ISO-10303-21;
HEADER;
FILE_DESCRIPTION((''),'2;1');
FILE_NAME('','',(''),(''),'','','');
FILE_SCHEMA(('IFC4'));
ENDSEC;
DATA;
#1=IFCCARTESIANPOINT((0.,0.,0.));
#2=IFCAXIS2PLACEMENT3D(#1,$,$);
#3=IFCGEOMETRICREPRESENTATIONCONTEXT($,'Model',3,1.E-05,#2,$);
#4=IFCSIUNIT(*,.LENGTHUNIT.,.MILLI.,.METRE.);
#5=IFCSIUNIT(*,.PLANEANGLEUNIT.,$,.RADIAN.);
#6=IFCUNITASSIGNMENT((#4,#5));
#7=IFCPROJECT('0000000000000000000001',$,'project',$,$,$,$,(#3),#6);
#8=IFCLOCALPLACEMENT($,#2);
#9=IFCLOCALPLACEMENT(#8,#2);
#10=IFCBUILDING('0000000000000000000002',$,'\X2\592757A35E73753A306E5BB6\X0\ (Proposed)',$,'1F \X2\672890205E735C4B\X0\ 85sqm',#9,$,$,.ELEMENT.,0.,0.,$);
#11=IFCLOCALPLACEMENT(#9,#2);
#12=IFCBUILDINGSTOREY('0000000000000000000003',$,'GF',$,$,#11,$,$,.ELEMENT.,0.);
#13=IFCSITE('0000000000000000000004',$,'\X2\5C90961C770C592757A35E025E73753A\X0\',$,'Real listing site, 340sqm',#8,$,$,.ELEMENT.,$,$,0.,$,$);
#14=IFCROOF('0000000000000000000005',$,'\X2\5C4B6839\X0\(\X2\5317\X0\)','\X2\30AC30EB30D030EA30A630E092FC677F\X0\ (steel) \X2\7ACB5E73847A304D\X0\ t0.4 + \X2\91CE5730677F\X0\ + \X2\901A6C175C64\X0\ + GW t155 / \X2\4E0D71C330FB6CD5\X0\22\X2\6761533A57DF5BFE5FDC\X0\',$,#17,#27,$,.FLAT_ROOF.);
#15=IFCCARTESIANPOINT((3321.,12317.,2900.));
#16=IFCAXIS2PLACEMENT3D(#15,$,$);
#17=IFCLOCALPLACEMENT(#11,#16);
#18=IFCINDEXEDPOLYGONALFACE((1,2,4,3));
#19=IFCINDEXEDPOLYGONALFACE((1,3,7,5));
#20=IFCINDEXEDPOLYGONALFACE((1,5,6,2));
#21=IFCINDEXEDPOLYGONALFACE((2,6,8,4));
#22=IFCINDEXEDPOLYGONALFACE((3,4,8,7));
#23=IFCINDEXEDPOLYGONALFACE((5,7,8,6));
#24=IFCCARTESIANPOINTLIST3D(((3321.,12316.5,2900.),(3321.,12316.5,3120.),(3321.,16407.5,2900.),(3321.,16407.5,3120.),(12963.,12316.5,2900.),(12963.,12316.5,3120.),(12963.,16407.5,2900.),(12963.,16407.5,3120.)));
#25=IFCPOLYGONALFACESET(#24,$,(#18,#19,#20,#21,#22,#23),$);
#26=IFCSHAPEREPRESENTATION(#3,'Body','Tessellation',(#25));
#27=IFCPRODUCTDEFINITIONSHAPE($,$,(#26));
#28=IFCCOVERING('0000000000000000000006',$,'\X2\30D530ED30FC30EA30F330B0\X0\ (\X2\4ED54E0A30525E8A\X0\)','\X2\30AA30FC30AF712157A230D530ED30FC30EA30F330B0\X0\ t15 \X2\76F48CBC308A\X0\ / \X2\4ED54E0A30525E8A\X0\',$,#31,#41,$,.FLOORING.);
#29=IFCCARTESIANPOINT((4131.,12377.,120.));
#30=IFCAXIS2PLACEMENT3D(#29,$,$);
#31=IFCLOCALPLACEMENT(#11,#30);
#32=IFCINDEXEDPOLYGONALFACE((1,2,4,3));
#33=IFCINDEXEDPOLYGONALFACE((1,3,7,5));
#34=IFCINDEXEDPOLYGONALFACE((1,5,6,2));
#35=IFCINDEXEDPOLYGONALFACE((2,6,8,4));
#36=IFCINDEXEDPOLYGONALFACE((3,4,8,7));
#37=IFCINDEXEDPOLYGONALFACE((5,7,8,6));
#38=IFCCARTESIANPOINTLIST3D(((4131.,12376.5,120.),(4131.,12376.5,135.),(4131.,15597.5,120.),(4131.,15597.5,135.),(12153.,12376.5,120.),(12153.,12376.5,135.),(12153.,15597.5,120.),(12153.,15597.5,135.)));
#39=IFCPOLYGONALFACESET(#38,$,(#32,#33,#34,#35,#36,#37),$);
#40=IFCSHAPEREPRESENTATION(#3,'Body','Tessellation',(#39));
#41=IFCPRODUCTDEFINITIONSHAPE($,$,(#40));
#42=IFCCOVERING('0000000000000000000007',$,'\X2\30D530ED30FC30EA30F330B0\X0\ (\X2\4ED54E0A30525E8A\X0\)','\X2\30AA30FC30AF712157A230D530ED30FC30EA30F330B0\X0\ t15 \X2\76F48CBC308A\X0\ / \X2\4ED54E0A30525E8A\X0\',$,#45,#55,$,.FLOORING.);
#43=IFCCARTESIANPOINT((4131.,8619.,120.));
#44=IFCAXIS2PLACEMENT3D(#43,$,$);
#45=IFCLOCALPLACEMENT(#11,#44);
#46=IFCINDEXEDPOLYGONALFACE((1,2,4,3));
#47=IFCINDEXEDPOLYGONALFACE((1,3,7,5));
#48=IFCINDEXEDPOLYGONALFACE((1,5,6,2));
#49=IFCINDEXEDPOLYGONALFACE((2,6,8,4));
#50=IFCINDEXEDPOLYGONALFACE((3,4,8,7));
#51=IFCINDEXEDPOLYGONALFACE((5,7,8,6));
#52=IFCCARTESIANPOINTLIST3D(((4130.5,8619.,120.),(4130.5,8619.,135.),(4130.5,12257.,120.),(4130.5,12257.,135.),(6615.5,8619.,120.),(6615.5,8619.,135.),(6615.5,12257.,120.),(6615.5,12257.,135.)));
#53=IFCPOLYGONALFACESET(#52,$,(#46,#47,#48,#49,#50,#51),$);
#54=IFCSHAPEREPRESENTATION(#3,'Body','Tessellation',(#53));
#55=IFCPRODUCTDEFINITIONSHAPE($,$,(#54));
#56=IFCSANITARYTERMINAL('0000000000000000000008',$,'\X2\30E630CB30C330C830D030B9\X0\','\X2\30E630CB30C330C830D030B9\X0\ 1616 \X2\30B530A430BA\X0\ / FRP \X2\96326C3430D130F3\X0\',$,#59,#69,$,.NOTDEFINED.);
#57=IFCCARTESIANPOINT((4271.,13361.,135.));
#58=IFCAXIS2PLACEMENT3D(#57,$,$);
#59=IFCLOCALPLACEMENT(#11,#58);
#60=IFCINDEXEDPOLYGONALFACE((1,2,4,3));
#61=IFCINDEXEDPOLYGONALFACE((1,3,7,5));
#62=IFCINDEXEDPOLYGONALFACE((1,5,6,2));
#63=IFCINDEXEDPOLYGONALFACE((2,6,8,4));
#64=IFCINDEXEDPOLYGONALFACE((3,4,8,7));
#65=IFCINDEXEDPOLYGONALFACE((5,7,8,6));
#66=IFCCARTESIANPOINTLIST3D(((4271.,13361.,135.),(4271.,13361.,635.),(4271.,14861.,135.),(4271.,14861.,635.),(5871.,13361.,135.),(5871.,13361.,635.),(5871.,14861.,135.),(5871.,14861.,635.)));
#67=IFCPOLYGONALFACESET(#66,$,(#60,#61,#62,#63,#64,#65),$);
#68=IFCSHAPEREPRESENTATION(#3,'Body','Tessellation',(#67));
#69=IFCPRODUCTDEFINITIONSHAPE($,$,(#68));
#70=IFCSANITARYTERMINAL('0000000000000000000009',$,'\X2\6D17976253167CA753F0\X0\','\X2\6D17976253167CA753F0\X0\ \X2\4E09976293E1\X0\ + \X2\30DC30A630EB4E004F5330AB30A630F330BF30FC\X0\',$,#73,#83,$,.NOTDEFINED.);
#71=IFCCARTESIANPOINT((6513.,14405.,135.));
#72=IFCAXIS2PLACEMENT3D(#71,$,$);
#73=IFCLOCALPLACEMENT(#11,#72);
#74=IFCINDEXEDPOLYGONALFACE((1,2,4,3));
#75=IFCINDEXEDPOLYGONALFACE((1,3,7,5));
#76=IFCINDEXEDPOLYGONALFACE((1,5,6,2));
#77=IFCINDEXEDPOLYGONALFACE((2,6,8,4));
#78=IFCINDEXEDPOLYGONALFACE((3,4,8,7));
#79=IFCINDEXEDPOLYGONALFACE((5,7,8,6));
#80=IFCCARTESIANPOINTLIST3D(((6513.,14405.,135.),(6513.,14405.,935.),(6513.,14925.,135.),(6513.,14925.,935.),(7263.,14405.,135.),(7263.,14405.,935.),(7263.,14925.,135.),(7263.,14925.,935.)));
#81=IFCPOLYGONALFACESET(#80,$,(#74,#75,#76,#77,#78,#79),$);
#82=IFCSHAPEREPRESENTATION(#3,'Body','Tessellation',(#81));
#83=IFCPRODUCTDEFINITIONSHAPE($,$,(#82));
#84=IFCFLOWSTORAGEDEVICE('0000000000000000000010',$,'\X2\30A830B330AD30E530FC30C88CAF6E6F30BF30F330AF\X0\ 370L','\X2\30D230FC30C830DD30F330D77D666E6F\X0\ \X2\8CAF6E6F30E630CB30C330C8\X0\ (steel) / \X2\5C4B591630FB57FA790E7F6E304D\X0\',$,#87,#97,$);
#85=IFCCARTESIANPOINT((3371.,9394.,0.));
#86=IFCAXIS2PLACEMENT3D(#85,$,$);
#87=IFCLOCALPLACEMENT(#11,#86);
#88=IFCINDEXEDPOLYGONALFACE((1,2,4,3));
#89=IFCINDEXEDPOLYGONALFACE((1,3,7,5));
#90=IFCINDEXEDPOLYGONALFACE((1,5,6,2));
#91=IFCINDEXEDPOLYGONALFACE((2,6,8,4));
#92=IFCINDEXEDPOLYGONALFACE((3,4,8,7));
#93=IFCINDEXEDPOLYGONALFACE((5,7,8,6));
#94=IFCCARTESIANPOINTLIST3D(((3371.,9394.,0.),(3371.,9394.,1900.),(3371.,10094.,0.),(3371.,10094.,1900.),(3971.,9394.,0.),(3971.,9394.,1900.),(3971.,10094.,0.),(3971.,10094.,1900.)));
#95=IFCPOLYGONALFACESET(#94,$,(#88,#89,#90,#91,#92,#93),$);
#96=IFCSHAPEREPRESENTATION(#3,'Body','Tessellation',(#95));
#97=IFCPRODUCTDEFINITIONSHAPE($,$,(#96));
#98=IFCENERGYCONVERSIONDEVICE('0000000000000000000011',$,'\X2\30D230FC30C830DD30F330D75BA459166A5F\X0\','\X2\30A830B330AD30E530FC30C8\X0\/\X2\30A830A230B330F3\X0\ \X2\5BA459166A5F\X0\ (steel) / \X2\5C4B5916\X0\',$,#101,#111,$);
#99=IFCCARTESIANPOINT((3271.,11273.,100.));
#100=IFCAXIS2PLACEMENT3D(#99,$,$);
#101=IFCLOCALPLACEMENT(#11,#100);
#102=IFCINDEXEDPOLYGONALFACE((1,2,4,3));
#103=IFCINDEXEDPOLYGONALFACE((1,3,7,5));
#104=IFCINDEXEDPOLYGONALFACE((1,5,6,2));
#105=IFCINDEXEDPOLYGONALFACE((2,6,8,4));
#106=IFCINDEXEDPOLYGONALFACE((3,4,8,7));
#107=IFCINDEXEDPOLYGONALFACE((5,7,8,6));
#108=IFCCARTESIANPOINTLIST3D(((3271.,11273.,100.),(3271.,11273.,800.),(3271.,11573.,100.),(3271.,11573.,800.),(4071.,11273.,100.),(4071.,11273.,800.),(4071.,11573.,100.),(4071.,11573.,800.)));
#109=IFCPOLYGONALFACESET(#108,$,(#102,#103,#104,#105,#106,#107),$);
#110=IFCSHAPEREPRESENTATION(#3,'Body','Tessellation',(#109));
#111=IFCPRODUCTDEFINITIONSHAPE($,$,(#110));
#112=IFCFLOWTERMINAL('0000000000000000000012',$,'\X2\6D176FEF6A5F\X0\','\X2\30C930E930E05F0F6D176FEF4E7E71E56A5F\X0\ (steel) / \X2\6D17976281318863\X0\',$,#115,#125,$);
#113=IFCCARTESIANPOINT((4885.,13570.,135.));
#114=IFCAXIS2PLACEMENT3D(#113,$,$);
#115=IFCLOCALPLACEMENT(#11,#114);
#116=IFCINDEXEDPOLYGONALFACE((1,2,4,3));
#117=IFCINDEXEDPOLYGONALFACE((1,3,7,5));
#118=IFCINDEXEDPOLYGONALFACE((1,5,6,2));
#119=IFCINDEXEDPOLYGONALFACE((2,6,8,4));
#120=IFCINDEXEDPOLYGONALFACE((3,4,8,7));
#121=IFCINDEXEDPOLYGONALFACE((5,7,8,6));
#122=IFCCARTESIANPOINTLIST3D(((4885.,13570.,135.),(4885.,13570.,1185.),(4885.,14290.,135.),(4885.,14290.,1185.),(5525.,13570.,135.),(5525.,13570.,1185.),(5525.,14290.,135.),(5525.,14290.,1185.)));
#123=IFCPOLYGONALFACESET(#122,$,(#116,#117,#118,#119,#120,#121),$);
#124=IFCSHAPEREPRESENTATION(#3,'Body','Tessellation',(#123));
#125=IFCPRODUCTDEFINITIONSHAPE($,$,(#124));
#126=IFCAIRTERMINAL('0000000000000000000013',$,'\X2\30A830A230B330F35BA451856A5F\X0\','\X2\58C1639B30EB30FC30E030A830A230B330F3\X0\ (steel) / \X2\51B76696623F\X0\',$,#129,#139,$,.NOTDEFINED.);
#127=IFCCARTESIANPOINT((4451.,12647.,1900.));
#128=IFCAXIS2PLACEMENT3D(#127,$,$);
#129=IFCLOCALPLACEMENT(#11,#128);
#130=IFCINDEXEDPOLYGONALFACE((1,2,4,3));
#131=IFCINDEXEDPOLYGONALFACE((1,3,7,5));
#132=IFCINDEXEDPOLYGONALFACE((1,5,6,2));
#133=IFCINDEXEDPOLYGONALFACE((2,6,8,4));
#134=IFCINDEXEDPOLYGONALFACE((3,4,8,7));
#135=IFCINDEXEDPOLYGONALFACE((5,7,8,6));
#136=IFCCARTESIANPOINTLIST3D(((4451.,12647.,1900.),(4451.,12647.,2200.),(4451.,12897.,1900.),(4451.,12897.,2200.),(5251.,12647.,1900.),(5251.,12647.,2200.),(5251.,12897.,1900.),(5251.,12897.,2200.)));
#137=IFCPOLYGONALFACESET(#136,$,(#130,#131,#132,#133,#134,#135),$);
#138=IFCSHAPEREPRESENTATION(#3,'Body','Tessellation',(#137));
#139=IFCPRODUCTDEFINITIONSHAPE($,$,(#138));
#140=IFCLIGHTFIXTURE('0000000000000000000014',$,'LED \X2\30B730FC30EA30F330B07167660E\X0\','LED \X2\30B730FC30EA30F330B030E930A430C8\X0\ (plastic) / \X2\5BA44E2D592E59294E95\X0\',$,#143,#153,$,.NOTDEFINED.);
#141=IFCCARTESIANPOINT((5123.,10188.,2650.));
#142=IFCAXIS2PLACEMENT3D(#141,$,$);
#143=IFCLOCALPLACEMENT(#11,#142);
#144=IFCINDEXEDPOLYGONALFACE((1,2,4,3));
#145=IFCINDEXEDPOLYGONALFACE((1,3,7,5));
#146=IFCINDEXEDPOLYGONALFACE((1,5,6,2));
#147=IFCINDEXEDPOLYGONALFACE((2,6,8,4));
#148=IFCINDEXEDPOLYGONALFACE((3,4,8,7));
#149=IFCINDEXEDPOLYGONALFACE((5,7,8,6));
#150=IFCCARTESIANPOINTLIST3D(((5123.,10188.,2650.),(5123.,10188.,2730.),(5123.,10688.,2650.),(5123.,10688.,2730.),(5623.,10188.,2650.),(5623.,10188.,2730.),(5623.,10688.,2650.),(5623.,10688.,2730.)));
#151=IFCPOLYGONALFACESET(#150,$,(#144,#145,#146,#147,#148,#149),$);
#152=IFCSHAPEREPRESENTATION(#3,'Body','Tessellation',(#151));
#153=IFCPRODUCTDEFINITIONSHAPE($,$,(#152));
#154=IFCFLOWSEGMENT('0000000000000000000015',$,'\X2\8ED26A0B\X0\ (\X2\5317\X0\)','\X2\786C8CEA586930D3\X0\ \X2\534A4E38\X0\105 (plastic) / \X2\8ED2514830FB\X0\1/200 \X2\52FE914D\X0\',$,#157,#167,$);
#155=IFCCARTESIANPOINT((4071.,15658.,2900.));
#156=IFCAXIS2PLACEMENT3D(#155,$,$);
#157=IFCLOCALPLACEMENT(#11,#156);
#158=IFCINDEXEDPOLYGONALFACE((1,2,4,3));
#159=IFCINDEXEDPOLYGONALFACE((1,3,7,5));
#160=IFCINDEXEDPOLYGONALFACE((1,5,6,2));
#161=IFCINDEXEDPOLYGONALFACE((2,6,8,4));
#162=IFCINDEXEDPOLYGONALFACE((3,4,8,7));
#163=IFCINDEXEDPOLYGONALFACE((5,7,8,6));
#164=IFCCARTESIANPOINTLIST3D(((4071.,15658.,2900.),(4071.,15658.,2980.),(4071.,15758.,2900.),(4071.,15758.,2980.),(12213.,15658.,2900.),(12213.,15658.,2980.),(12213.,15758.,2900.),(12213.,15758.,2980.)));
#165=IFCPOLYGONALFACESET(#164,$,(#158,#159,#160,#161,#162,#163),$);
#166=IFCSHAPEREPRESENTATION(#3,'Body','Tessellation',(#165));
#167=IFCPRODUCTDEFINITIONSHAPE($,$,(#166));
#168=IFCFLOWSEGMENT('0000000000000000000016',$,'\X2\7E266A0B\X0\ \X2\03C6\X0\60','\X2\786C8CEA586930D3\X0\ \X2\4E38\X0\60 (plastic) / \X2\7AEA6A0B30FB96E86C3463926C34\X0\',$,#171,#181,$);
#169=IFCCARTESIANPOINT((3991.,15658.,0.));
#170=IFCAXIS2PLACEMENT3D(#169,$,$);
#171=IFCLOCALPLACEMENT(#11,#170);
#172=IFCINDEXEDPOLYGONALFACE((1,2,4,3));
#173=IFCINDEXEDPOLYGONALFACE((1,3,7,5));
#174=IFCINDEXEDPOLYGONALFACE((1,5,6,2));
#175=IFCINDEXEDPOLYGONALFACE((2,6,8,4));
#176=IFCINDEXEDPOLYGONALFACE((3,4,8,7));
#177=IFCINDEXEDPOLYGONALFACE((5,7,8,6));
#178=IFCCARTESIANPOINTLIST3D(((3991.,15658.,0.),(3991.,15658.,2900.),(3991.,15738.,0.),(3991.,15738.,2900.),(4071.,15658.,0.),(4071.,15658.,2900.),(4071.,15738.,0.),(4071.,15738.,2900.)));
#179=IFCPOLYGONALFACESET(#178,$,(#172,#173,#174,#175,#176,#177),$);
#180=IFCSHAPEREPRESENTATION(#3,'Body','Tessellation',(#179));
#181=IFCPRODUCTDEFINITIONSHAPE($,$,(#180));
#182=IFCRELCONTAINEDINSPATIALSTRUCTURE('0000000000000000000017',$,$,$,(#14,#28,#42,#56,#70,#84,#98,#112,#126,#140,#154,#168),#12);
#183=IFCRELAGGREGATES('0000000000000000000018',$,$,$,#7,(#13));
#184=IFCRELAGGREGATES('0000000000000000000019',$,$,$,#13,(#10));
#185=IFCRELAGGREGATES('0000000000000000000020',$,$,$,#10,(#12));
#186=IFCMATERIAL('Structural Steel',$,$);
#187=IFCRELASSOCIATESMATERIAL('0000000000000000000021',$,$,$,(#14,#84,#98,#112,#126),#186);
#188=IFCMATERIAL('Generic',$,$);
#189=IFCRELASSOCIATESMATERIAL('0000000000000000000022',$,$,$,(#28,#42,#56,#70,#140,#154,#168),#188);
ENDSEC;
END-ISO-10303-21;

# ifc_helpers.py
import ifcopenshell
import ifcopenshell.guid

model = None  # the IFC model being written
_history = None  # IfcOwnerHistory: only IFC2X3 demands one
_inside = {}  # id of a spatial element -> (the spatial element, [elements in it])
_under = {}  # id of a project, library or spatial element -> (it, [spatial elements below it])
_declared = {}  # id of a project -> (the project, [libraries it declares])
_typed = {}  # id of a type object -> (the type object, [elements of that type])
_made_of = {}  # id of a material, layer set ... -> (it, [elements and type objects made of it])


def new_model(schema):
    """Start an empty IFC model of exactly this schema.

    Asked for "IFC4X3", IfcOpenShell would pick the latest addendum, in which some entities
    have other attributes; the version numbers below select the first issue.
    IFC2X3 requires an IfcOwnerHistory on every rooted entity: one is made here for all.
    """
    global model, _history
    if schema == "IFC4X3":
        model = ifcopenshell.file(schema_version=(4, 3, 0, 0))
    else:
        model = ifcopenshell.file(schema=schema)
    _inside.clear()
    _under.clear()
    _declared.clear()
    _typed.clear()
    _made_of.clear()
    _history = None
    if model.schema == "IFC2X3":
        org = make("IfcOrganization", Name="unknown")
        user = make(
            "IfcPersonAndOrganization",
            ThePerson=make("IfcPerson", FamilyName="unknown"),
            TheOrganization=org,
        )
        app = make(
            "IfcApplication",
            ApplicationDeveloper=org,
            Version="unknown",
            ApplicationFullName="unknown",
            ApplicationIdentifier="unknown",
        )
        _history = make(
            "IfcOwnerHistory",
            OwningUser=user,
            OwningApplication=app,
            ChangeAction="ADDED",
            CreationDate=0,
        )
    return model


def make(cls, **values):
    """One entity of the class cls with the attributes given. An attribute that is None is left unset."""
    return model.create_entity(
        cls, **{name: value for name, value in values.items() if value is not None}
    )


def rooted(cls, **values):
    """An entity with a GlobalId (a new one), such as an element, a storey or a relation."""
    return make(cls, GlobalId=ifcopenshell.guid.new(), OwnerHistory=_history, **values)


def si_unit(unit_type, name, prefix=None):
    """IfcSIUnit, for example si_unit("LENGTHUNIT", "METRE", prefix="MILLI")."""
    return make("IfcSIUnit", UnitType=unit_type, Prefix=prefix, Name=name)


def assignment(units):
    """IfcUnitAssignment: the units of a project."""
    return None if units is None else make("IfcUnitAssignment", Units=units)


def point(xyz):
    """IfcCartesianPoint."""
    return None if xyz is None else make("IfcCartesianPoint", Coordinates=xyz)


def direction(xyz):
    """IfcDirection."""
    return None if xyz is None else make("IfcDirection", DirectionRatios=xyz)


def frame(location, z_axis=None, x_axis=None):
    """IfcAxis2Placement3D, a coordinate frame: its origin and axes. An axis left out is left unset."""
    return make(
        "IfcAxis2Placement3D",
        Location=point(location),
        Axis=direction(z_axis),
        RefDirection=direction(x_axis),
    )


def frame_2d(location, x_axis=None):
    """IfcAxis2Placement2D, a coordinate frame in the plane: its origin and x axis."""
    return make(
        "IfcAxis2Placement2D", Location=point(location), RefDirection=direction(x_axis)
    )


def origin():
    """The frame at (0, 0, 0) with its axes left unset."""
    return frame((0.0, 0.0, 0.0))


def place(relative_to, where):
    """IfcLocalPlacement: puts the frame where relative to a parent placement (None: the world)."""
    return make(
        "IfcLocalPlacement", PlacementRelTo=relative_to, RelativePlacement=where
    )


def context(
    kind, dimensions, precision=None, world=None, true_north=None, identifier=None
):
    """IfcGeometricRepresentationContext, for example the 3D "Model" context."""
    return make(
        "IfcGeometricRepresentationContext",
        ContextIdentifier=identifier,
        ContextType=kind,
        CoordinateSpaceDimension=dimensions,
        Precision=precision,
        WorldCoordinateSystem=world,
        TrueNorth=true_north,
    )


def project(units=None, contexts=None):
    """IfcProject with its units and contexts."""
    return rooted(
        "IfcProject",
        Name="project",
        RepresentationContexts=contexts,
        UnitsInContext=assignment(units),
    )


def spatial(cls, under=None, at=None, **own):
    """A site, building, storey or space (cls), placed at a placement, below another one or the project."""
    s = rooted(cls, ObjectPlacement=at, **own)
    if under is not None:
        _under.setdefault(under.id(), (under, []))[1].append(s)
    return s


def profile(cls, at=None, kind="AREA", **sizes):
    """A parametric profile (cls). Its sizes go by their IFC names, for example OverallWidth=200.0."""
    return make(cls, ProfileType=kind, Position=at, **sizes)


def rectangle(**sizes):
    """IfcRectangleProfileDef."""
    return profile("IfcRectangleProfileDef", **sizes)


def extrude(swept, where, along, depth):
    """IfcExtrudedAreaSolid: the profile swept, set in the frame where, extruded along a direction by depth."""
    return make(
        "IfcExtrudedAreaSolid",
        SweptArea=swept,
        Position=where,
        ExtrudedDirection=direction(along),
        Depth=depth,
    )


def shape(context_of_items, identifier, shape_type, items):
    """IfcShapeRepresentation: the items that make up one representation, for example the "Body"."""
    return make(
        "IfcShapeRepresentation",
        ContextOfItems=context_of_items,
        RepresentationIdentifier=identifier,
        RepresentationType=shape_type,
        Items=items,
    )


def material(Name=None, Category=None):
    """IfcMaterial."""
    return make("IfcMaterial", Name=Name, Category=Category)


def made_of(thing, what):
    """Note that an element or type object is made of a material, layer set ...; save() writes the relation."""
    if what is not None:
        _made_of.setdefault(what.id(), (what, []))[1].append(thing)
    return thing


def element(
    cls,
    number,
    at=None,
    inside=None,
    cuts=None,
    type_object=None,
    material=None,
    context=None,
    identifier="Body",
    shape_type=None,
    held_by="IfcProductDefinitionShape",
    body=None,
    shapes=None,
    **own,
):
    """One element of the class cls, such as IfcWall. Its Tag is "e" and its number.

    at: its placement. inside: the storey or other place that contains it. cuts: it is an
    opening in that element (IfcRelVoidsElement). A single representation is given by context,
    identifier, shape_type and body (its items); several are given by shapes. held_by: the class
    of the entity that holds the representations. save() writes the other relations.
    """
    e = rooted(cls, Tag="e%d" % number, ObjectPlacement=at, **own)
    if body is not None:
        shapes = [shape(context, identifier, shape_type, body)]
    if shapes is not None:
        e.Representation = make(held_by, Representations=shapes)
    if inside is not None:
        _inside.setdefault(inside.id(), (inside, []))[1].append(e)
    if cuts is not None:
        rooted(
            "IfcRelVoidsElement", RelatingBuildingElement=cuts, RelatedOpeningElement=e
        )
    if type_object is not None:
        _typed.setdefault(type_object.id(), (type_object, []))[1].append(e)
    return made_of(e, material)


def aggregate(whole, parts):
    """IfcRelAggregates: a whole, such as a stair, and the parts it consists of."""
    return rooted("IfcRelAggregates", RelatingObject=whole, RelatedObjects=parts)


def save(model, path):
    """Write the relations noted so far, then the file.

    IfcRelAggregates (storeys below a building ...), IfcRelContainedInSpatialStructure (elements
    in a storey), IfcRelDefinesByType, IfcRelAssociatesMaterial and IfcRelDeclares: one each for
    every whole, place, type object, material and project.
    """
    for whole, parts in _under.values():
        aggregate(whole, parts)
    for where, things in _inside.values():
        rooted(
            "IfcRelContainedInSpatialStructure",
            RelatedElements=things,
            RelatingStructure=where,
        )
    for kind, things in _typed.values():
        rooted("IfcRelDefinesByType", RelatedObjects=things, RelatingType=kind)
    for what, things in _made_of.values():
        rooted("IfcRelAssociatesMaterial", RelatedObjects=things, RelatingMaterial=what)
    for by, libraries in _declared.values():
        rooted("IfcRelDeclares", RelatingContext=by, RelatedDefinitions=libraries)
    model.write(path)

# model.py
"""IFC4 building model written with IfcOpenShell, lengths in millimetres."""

from ifc_helpers import new_model, si_unit, frame, frame_2d, origin, place, context, project, spatial, rectangle, extrude, material, element, save


model = new_model("IFC4")

# Units and contexts
model_context = context("Model", 3, precision=1e-05, world=origin())
ifc_project = project(units=[si_unit("LENGTHUNIT", "METRE", prefix="MILLI"), si_unit("PLANEANGLEUNIT", "RADIAN")], contexts=[model_context])

# Site, building, storey
site_placement = place(None, origin())
site = spatial("IfcSite", under=ifc_project, at=site_placement, Name="岐阜県大垣市平町", ObjectType="Real listing site, 340sqm", CompositionType="ELEMENT", RefElevation=0.0)
building_placement = place(site_placement, origin())
building = spatial("IfcBuilding", under=site, at=building_placement, Name="大垣平町の家 (Proposed)", ObjectType="1F 木造平屋 85sqm", CompositionType="ELEMENT", ElevationOfRefHeight=0.0, ElevationOfTerrain=0.0)
storey_placement = place(building_placement, origin())
storey = spatial("IfcBuildingStorey", under=building, at=storey_placement, Name="GF", CompositionType="ELEMENT", Elevation=0.0)

# Roof
ifc_material_1 = material(Name="Structural Steel")
roof_placement = place(storey_placement, frame((3321.0, 12317.0, 2900.0)))
element("IfcRoof", 1, at=roof_placement, inside=storey, material=ifc_material_1, Name="屋根(北)", Description="ガルバリウム鋼板 (steel) 立平葺き t0.4 + 野地板 + 通気層 + GW t155 / 不燃・法22条区域対応", PredefinedType="FLAT_ROOF", context=model_context, shape_type="SweptSolid", body=[
    extrude(rectangle(XDim=9642.0, YDim=4091.0, at=frame_2d((4821.0, 2045.0))), frame((3321.0, 12317.0, 2900.0)), (0.0, 0.0, 1.0), 220.0),
])

# Coverings
ifc_material_2 = material(Name="Generic")
covering_1_placement = place(storey_placement, frame((4131.0, 12377.0, 120.0)))
element("IfcCovering", 2, at=covering_1_placement, inside=storey, material=ifc_material_2, Name="フローリング (仕上げ床)", Description="オーク無垢フローリング t15 直貼り / 仕上げ床", PredefinedType="FLOORING", context=model_context, shape_type="SweptSolid", body=[
    extrude(rectangle(XDim=8022.0, YDim=3221.0, at=frame_2d((4011.0, 1610.0))), frame((4131.0, 12377.0, 120.0)), (0.0, 0.0, 1.0), 15.0),
])
covering_2_placement = place(storey_placement, frame((4131.0, 8619.0, 120.0)))
element("IfcCovering", 3, at=covering_2_placement, inside=storey, material=ifc_material_2, Name="フローリング (仕上げ床)", Description="オーク無垢フローリング t15 直貼り / 仕上げ床", PredefinedType="FLOORING", context=model_context, shape_type="SweptSolid", body=[
    extrude(rectangle(XDim=2485.0, YDim=3638.0, at=frame_2d((1242.0, 1819.0))), frame((4131.0, 8619.0, 120.0)), (0.0, 0.0, 1.0), 15.0),
])

# Sanitary terminals
sanitary_terminal_1_placement = place(storey_placement, frame((4271.0, 13361.0, 135.0)))
element("IfcSanitaryTerminal", 4, at=sanitary_terminal_1_placement, inside=storey, material=ifc_material_2, Name="ユニットバス", Description="ユニットバス 1616 サイズ / FRP 防水パン", PredefinedType="NOTDEFINED", context=model_context, shape_type="SweptSolid", body=[
    extrude(rectangle(XDim=1600.0, YDim=1500.0, at=frame_2d((800.0, 750.0))), frame((4271.0, 13361.0, 135.0)), (0.0, 0.0, 1.0), 500.0),
])
sanitary_terminal_2_placement = place(storey_placement, frame((6513.0, 14405.0, 135.0)))
element("IfcSanitaryTerminal", 5, at=sanitary_terminal_2_placement, inside=storey, material=ifc_material_2, Name="洗面化粧台", Description="洗面化粧台 三面鏡 + ボウル一体カウンター", PredefinedType="NOTDEFINED", context=model_context, shape_type="SweptSolid", body=[
    extrude(rectangle(XDim=750.0, YDim=520.0, at=frame_2d((375.0, 260.0))), frame((6513.0, 14405.0, 135.0)), (0.0, 0.0, 1.0), 800.0),
])

# Flow storage device
flow_storage_device_placement = place(storey_placement, frame((3371.0, 9394.0, 0.0)))
element("IfcFlowStorageDevice", 6, at=flow_storage_device_placement, inside=storey, material=ifc_material_1, Name="エコキュート貯湯タンク 370L", Description="ヒートポンプ給湯 貯湯ユニット (steel) / 屋外・基礎置き", context=model_context, shape_type="SweptSolid", body=[
    extrude(rectangle(XDim=600.0, YDim=700.0, at=frame_2d((300.0, 350.0))), frame((3371.0, 9394.0, 0.0)), (0.0, 0.0, 1.0), 1900.0),
])

# Energy conversion device
energy_conversion_device_placement = place(storey_placement, frame((3271.0, 11273.0, 100.0)))
element("IfcEnergyConversionDevice", 7, at=energy_conversion_device_placement, inside=storey, material=ifc_material_1, Name="ヒートポンプ室外機", Description="エコキュート/エアコン 室外機 (steel) / 屋外", context=model_context, shape_type="SweptSolid", body=[
    extrude(rectangle(XDim=800.0, YDim=300.0, at=frame_2d((400.0, 150.0))), frame((3271.0, 11273.0, 100.0)), (0.0, 0.0, 1.0), 700.0),
])

# Flow terminal
flow_terminal_placement = place(storey_placement, frame((4885.0, 13570.0, 135.0)))
element("IfcFlowTerminal", 8, at=flow_terminal_placement, inside=storey, material=ifc_material_1, Name="洗濯機", Description="ドラム式洗濯乾燥機 (steel) / 洗面脱衣", context=model_context, shape_type="SweptSolid", body=[
    extrude(rectangle(XDim=640.0, YDim=720.0, at=frame_2d((320.0, 360.0))), frame((4885.0, 13570.0, 135.0)), (0.0, 0.0, 1.0), 1050.0),
])

# Air terminal
air_terminal_placement = place(storey_placement, frame((4451.0, 12647.0, 1900.0)))
element("IfcAirTerminal", 9, at=air_terminal_placement, inside=storey, material=ifc_material_1, Name="エアコン室内機", Description="壁掛ルームエアコン (steel) / 冷暖房", PredefinedType="NOTDEFINED", context=model_context, shape_type="SweptSolid", body=[
    extrude(rectangle(XDim=800.0, YDim=250.0, at=frame_2d((400.0, 125.0))), frame((4451.0, 12647.0, 1900.0)), (0.0, 0.0, 1.0), 300.0),
])

# Light fixture
light_fixture_placement = place(storey_placement, frame((5123.0, 10188.0, 2650.0)))
element("IfcLightFixture", 10, at=light_fixture_placement, inside=storey, material=ifc_material_2, Name="LED シーリング照明", Description="LED シーリングライト (plastic) / 室中央天井", PredefinedType="NOTDEFINED", context=model_context, shape_type="SweptSolid", body=[
    extrude(rectangle(XDim=500.0, YDim=500.0, at=frame_2d((250.0, 250.0))), frame((5123.0, 10188.0, 2650.0)), (0.0, 0.0, 1.0), 80.0),
])

# Flow segments
flow_segment_1_placement = place(storey_placement, frame((4071.0, 15658.0, 2900.0)))
element("IfcFlowSegment", 11, at=flow_segment_1_placement, inside=storey, material=ifc_material_2, Name="軒樋 (北)", Description="硬質塩ビ 半丸105 (plastic) / 軒先・1/200 勾配", context=model_context, shape_type="SweptSolid", body=[
    extrude(rectangle(XDim=8142.0, YDim=100.0, at=frame_2d((4071.0, 50.0))), frame((4071.0, 15658.0, 2900.0)), (0.0, 0.0, 1.0), 80.0),
])
flow_segment_2_placement = place(storey_placement, frame((3991.0, 15658.0, 0.0)))
element("IfcFlowSegment", 12, at=flow_segment_2_placement, inside=storey, material=ifc_material_2, Name="縦樋 φ60", Description="硬質塩ビ 丸60 (plastic) / 竪樋・雨水排水", context=model_context, shape_type="SweptSolid", body=[
    extrude(rectangle(XDim=80.0, YDim=80.0, at=frame_2d((40.0, 40.0))), frame((3991.0, 15658.0, 0.0)), (0.0, 0.0, 1.0), 2900.0),
])

save(model, "model.ifc")
